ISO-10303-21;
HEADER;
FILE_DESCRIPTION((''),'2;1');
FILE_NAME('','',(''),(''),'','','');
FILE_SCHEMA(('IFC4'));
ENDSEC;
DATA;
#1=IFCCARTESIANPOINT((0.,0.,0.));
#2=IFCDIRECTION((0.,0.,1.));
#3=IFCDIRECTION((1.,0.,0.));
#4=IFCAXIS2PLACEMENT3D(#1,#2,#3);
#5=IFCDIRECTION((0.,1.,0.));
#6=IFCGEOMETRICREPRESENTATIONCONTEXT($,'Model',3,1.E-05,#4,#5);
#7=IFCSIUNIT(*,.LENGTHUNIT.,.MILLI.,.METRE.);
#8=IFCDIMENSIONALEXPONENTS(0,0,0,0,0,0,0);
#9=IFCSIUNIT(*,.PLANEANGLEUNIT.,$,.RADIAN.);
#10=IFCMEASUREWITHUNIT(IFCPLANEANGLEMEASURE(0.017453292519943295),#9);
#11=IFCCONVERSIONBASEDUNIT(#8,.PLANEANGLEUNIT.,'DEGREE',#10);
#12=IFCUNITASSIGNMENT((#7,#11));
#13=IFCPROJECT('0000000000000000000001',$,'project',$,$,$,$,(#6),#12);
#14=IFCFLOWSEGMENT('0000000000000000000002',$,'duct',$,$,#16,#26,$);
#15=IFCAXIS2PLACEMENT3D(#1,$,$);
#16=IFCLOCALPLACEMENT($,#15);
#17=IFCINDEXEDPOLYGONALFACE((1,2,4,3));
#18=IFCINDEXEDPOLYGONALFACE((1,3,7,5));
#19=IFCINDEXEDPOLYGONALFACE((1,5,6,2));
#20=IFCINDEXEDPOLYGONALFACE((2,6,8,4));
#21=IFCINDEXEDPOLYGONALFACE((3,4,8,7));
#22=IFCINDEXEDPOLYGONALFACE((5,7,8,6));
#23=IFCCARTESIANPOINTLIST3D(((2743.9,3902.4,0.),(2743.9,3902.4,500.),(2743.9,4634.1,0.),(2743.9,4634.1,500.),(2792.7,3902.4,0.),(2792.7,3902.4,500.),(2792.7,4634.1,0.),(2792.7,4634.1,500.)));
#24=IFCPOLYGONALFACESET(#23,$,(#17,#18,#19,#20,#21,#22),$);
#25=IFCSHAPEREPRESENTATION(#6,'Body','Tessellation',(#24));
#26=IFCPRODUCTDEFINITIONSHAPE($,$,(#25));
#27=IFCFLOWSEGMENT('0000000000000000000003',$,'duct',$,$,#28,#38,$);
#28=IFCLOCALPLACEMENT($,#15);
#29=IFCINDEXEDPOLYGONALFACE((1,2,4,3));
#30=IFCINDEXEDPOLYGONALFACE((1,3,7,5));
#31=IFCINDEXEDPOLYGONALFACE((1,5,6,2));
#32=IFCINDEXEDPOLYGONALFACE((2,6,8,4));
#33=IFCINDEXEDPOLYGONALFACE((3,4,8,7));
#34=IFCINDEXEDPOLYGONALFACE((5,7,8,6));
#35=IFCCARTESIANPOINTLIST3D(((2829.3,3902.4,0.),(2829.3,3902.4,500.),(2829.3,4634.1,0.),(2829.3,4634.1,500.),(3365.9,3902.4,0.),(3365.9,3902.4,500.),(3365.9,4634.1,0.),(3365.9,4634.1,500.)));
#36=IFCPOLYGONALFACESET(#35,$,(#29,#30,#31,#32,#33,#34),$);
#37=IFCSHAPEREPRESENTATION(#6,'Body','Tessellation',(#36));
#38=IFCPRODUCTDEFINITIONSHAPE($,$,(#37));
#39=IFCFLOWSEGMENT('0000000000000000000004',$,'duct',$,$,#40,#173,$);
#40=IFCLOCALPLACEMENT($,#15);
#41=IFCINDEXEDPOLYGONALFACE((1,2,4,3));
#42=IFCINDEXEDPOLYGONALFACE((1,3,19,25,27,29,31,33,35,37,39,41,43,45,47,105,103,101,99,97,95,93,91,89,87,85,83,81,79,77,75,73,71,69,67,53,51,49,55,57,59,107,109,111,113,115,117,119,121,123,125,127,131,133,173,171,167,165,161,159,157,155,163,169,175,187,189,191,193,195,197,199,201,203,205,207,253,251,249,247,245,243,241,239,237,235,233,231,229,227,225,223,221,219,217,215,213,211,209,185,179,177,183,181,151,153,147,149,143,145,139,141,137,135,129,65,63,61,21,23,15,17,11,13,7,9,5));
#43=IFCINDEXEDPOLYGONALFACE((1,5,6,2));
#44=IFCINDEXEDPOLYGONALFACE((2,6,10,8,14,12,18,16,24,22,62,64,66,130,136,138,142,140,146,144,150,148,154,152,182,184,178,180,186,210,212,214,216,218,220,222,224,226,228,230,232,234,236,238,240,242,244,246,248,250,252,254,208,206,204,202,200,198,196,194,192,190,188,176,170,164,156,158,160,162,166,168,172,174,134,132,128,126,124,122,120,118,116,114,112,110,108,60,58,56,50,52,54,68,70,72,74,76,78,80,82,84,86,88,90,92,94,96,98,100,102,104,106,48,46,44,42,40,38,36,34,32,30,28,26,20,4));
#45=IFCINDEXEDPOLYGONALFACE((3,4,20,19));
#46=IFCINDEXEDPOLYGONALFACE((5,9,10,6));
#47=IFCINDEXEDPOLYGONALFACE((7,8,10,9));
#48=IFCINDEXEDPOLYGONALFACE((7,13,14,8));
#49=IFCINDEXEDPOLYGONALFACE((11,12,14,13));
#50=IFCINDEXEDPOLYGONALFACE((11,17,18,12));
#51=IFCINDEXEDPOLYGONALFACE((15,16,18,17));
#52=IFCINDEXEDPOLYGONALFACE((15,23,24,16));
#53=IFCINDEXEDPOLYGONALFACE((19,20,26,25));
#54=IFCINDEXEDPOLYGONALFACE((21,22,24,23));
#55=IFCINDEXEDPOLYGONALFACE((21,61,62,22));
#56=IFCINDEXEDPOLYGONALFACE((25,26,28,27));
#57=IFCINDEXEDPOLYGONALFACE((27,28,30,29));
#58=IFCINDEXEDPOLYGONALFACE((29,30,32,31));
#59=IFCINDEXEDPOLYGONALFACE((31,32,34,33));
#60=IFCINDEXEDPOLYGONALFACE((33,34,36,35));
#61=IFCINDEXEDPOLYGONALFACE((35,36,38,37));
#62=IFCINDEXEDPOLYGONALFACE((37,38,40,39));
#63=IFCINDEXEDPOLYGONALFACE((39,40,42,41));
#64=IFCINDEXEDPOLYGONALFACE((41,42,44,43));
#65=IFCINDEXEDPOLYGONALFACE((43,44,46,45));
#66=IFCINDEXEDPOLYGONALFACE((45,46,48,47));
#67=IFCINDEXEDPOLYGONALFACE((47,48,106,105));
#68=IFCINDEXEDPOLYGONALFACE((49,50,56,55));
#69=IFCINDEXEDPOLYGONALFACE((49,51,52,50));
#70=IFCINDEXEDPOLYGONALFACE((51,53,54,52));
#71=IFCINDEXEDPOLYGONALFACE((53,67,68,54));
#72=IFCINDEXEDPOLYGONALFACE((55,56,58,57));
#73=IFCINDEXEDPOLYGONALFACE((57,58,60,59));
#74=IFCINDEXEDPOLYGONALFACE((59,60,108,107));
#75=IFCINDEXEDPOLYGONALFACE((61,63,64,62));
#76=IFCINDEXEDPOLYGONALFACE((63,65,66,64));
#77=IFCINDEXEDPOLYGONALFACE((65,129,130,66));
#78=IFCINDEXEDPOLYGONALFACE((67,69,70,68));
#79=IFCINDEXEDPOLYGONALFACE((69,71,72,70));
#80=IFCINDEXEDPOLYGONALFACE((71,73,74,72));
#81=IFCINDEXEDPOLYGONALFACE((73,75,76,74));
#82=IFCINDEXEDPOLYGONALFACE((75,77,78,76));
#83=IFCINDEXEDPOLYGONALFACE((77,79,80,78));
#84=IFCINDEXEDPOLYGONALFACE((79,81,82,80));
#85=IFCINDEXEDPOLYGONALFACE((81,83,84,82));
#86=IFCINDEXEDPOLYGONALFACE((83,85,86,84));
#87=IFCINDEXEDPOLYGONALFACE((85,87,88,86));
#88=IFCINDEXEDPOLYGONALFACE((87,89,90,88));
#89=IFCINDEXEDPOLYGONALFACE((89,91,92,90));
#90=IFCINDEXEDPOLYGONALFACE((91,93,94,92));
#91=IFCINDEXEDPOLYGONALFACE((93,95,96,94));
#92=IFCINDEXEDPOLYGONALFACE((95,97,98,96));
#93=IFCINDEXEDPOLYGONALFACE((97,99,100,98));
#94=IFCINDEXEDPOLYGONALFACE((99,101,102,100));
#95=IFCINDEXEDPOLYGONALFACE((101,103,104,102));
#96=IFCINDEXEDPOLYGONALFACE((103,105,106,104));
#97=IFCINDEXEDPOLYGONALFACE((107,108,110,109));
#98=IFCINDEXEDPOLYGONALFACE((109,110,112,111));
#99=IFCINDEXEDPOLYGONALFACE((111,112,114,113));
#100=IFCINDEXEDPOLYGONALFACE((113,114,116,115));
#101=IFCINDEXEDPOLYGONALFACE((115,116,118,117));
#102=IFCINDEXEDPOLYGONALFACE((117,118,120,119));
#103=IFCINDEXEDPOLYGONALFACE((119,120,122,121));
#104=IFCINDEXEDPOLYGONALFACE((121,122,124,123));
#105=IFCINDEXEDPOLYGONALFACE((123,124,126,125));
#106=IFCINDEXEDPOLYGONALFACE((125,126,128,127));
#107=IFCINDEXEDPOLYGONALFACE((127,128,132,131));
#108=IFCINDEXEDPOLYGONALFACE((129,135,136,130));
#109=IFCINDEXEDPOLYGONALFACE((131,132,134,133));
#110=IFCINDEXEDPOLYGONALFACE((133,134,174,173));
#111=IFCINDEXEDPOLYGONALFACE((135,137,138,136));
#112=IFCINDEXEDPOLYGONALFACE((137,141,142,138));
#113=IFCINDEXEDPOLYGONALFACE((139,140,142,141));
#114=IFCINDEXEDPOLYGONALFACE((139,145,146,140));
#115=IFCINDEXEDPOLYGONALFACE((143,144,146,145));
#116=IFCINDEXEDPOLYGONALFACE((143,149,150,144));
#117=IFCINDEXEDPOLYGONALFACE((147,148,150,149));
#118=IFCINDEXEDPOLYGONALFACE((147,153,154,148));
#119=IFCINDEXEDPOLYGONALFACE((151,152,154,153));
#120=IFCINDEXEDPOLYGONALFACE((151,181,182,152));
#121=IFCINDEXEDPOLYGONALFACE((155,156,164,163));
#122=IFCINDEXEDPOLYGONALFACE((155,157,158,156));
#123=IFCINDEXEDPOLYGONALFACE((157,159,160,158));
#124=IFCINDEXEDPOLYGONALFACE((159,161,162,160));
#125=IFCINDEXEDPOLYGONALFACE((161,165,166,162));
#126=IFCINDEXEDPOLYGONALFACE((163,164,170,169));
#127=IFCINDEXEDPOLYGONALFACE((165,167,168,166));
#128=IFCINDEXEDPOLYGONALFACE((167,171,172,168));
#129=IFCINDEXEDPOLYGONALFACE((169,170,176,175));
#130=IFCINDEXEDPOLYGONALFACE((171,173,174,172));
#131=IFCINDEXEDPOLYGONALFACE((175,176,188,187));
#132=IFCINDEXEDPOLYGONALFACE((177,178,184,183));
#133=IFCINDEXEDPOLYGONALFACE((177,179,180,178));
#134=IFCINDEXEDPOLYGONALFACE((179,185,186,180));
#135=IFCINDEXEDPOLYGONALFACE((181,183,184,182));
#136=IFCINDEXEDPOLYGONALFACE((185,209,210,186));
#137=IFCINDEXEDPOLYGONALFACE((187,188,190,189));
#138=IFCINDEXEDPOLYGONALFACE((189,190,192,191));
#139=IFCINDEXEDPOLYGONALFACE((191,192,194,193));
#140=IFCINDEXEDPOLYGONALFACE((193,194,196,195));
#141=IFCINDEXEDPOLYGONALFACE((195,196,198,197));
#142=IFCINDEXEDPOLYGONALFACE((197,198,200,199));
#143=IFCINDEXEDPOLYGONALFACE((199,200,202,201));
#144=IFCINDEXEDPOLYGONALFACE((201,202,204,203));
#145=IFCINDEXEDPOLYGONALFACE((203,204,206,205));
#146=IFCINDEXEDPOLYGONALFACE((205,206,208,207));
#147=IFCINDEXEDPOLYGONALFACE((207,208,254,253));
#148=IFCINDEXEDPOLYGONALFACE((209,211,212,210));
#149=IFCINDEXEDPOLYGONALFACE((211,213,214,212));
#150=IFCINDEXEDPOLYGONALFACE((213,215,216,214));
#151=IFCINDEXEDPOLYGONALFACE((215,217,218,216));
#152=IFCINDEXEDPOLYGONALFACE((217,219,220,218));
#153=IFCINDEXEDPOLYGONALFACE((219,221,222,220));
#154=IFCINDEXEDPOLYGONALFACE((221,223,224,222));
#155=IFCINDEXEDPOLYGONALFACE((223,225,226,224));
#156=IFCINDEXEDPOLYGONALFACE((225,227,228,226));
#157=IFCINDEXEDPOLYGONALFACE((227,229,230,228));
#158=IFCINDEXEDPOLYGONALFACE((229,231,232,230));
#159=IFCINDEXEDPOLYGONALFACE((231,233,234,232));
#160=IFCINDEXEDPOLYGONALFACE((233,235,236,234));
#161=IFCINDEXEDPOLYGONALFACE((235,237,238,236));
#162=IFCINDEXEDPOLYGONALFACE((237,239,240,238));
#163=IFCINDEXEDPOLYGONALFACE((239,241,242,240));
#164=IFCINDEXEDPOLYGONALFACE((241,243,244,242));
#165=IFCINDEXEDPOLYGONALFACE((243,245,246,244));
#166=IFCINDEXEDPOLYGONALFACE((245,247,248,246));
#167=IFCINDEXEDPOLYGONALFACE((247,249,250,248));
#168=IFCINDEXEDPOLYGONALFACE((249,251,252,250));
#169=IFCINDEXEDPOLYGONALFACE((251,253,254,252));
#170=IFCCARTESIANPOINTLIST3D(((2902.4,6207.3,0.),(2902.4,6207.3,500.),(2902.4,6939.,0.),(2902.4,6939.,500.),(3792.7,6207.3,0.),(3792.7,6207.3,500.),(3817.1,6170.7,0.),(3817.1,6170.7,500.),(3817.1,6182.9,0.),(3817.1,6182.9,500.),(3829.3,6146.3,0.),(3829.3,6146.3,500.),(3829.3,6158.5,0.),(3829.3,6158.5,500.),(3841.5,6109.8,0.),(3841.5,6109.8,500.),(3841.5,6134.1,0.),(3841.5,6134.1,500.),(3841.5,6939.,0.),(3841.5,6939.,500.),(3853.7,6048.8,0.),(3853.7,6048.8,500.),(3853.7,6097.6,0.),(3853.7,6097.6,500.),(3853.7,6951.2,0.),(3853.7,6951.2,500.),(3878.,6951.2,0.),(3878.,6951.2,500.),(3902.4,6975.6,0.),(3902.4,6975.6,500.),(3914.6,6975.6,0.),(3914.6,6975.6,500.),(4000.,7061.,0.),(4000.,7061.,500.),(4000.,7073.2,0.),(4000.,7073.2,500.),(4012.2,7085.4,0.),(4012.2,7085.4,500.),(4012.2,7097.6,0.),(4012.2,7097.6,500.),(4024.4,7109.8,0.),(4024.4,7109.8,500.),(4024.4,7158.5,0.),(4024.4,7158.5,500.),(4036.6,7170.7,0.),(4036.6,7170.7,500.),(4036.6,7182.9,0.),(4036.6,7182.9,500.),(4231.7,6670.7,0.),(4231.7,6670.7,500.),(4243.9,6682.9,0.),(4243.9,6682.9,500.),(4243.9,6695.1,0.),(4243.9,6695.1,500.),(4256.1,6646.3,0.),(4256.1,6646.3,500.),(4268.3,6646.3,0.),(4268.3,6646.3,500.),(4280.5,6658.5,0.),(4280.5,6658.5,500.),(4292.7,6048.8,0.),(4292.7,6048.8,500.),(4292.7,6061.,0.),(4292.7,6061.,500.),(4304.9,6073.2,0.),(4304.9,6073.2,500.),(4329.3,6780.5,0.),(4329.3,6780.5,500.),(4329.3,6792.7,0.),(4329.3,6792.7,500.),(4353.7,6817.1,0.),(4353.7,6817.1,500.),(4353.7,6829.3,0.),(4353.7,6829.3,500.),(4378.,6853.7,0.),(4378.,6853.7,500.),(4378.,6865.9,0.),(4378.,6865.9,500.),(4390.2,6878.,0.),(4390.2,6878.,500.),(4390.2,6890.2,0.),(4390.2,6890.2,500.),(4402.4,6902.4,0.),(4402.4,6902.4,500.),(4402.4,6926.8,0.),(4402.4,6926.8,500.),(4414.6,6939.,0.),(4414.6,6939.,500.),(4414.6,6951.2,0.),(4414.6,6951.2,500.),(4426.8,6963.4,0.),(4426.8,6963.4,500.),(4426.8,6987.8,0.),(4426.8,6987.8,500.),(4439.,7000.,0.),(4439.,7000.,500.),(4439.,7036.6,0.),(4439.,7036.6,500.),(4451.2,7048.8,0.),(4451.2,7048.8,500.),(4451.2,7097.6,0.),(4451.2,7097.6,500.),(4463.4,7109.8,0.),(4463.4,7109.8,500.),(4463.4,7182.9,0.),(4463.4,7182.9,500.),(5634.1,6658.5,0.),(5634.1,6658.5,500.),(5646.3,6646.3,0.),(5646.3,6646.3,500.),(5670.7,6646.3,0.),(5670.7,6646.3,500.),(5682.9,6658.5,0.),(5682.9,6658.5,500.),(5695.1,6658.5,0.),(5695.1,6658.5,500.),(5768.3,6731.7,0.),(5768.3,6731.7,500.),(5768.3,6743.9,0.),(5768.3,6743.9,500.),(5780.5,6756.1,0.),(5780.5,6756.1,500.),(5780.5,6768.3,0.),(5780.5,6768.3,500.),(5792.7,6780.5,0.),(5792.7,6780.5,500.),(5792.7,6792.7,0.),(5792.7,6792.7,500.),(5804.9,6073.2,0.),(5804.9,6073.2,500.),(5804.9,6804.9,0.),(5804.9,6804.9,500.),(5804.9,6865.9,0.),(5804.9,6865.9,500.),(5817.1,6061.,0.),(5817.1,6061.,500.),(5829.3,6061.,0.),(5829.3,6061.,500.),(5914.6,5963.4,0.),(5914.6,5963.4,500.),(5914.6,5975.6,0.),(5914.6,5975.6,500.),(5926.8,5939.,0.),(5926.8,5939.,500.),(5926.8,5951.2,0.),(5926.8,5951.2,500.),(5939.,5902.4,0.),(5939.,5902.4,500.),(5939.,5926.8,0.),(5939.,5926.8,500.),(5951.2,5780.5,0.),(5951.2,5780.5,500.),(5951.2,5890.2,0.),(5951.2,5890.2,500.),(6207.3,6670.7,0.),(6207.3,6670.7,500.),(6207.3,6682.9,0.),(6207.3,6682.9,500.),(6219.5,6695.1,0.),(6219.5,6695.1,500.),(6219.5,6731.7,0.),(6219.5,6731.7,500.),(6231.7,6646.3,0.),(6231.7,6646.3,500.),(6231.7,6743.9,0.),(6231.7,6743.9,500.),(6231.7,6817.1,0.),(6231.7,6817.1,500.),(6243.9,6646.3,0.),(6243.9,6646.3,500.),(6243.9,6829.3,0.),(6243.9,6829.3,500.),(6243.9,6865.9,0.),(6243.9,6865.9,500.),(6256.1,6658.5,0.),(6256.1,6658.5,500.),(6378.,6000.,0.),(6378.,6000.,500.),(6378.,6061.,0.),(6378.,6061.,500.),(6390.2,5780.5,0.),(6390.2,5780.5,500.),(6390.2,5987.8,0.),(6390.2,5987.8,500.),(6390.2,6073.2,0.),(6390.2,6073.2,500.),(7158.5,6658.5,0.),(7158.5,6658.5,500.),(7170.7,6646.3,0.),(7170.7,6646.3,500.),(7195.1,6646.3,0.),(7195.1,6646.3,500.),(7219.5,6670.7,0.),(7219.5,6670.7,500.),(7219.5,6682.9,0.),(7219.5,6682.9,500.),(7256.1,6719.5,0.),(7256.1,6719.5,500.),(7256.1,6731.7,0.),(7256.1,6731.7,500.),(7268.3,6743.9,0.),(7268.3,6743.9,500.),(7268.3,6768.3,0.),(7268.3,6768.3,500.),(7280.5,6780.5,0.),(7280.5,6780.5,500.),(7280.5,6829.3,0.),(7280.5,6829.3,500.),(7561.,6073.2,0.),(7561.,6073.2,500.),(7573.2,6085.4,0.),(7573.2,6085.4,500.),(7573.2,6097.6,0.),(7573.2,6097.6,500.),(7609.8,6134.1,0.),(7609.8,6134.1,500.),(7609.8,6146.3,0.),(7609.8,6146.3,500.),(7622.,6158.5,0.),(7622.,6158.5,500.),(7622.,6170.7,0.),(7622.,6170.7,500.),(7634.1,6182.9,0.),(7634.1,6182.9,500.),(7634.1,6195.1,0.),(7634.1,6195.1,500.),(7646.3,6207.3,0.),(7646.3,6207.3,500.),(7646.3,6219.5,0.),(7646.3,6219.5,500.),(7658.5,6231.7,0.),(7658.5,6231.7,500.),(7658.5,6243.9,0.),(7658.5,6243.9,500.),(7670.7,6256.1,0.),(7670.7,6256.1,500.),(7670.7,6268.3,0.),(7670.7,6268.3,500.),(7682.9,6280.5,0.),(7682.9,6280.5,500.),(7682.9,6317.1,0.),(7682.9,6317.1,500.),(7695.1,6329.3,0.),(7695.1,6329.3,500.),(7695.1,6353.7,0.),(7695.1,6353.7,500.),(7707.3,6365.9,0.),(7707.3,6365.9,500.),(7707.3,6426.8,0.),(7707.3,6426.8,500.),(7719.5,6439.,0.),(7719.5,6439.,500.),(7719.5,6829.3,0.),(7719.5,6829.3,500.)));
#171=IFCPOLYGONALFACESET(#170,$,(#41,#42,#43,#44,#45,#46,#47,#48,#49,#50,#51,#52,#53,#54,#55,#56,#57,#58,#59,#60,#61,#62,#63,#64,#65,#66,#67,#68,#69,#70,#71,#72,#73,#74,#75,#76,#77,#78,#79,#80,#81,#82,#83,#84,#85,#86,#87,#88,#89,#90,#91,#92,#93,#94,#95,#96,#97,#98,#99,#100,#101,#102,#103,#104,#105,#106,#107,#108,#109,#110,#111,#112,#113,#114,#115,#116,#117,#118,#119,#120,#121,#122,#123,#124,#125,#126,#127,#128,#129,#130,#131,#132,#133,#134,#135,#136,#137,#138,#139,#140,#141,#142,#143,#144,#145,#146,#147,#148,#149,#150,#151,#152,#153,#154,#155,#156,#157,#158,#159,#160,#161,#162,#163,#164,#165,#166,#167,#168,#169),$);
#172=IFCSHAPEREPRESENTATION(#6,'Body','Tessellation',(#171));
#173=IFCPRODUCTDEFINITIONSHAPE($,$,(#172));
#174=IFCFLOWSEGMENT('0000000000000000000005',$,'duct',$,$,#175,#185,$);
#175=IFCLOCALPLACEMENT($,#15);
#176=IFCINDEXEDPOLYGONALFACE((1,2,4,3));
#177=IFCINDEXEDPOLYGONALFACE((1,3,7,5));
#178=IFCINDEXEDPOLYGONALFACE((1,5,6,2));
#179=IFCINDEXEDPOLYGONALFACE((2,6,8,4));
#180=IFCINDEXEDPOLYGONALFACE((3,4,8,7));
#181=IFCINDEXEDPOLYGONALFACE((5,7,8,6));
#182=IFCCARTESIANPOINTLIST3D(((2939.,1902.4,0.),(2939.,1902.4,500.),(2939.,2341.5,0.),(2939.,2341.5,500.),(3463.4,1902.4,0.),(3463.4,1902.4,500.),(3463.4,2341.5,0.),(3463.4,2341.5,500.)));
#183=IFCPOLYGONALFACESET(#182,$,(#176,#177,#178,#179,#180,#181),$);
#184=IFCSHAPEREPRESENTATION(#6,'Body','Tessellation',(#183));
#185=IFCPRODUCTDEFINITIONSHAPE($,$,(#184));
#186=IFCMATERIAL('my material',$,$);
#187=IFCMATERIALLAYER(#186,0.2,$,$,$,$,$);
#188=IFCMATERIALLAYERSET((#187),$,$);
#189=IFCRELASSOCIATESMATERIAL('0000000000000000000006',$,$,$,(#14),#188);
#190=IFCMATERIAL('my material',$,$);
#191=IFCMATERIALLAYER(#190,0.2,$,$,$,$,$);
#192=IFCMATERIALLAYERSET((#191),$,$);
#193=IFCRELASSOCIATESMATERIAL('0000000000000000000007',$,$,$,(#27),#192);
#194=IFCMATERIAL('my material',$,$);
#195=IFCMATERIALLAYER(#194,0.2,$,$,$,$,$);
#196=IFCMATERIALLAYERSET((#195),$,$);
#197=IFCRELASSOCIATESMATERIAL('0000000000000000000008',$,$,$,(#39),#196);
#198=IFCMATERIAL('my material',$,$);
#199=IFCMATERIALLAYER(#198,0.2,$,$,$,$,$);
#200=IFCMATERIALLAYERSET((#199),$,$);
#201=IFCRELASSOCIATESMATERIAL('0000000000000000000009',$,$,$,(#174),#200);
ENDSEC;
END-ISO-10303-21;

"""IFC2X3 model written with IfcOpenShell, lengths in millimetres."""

from ifc_helpers import new_model, entity, si_unit, converted_unit, direction, origin_with_axes, place, context, project, polyline, outline, extrude, material, layer, layer_set, layer_usage, element, save


model = new_model("IFC2X3")

# Units and contexts
model_context = context("Model", 3, precision=1e-05, world=origin_with_axes(), true_north=direction((0.0, 1.0, 0.0)))
ifc_project = project(units=[si_unit("LENGTHUNIT", "METRE", prefix="MILLI"), converted_unit("PLANEANGLEUNIT", "DEGREE", entity("IfcPlaneAngleMeasure", 0.017453292519943295), si_unit("PLANEANGLEUNIT", "RADIAN"), dimensions=[0, 0, 0, 0, 0, 0, 0])], contexts=[model_context])

# Flow segments
ifc_material_1 = material(Name="my material")
ifc_layer_1 = layer(ifc_material_1, 0.2)
ifc_layer_set_1 = layer_set([ifc_layer_1])
ifc_layer_usage_1 = layer_usage(ifc_layer_set_1, "AXIS2", "POSITIVE", -0.1)
flow_segment_1_placement = place(None, origin_with_axes())
element("IfcFlowSegment", 1, at=flow_segment_1_placement, material=ifc_layer_usage_1, Name="duct", context=model_context, shape_type="SweptSolid", body=[
    extrude(outline(polyline([(2743.9, 3902.4), (2792.7, 3902.4), (2792.7, 4634.1), (2743.9, 4634.1), (2743.9, 3902.4)])), origin_with_axes(), (0.0, 0.0, 1.0), 500.0),
])
ifc_material_2 = material(Name="my material")
ifc_layer_2 = layer(ifc_material_2, 0.2)
ifc_layer_set_2 = layer_set([ifc_layer_2])
ifc_layer_usage_2 = layer_usage(ifc_layer_set_2, "AXIS2", "POSITIVE", -0.1)
flow_segment_2_placement = place(None, origin_with_axes())
element("IfcFlowSegment", 2, at=flow_segment_2_placement, material=ifc_layer_usage_2, Name="duct", context=model_context, shape_type="SweptSolid", body=[
    extrude(outline(polyline([(2829.3, 3902.4), (3365.9, 3902.4), (3365.9, 4634.1), (2829.3, 4634.1), (2829.3, 3902.4)])), origin_with_axes(), (0.0, 0.0, 1.0), 500.0),
])
ifc_material_3 = material(Name="my material")
ifc_layer_3 = layer(ifc_material_3, 0.2)
ifc_layer_set_3 = layer_set([ifc_layer_3])
ifc_layer_usage_3 = layer_usage(ifc_layer_set_3, "AXIS2", "POSITIVE", -0.1)
flow_segment_3_placement = place(None, origin_with_axes())
element("IfcFlowSegment", 3, at=flow_segment_3_placement, material=ifc_layer_usage_3, Name="duct", context=model_context, shape_type="SweptSolid", body=[
    extrude(outline(polyline([(2902.4, 6207.3), (3792.7, 6207.3), (3817.1, 6182.9), (3817.1, 6170.7), (3829.3, 6158.5), (3829.3, 6146.3), (3841.5, 6134.1), (3841.5, 6109.8), (3853.7, 6097.6), (3853.7, 6048.8), (4292.7, 6048.8), (4292.7, 6061.0), (4304.9, 6073.2), (5804.9, 6073.2), (5817.1, 6061.0), (5829.3, 6061.0), (5914.6, 5975.6), (5914.6, 5963.4), (5926.8, 5951.2), (5926.8, 5939.0), (5939.0, 5926.8), (5939.0, 5902.4), (5951.2, 5890.2), (5951.2, 5780.5), (6390.2, 5780.5), (6390.2, 5987.8), (6378.0, 6000.0), (6378.0, 6061.0), (6390.2, 6073.2), (7561.0, 6073.2), (7573.2, 6085.4), (7573.2, 6097.6), (7609.8, 6134.1), (7609.8, 6146.3), (7622.0, 6158.5), (7622.0, 6170.7), (7634.1, 6182.9), (7634.1, 6195.1), (7646.3, 6207.3), (7646.3, 6219.5), (7658.5, 6231.7), (7658.5, 6243.9), (7670.7, 6256.1), (7670.7, 6268.3), (7682.9, 6280.5), (7682.9, 6317.1), (7695.1, 6329.3), (7695.1, 6353.7), (7707.3, 6365.9), (7707.3, 6426.8), (7719.5, 6439.0), (7719.5, 6829.3), (7280.5, 6829.3), (7280.5, 6780.5), (7268.3, 6768.3), (7268.3, 6743.9), (7256.1, 6731.7), (7256.1, 6719.5), (7219.5, 6682.9), (7219.5, 6670.7), (7195.1, 6646.3), (7170.7, 6646.3), (7158.5, 6658.5), (6256.1, 6658.5), (6243.9, 6646.3), (6231.7, 6646.3), (6207.3, 6670.7), (6207.3, 6682.9), (6219.5, 6695.1), (6219.5, 6731.7), (6231.7, 6743.9), (6231.7, 6817.1), (6243.9, 6829.3), (6243.9, 6865.9), (5804.9, 6865.9), (5804.9, 6804.9), (5792.7, 6792.7), (5792.7, 6780.5), (5780.5, 6768.3), (5780.5, 6756.1), (5768.3, 6743.9), (5768.3, 6731.7), (5695.1, 6658.5), (5682.9, 6658.5), (5670.7, 6646.3), (5646.3, 6646.3), (5634.1, 6658.5), (4280.5, 6658.5), (4268.3, 6646.3), (4256.1, 6646.3), (4231.7, 6670.7), (4243.9, 6682.9), (4243.9, 6695.1), (4329.3, 6780.5), (4329.3, 6792.7), (4353.7, 6817.1), (4353.7, 6829.3), (4378.0, 6853.7), (4378.0, 6865.9), (4390.2, 6878.0), (4390.2, 6890.2), (4402.4, 6902.4), (4402.4, 6926.8), (4414.6, 6939.0), (4414.6, 6951.2), (4426.8, 6963.4), (4426.8, 6987.8), (4439.0, 7000.0), (4439.0, 7036.6), (4451.2, 7048.8), (4451.2, 7097.6), (4463.4, 7109.8), (4463.4, 7182.9), (4036.6, 7182.9), (4036.6, 7170.7), (4024.4, 7158.5), (4024.4, 7109.8), (4012.2, 7097.6), (4012.2, 7085.4), (4000.0, 7073.2), (4000.0, 7061.0), (3914.6, 6975.6), (3902.4, 6975.6), (3878.0, 6951.2), (3853.7, 6951.2), (3841.5, 6939.0), (2902.4, 6939.0), (2902.4, 6207.3)])), origin_with_axes(), (0.0, 0.0, 1.0), 500.0),
])
ifc_material_4 = material(Name="my material")
ifc_layer_4 = layer(ifc_material_4, 0.2)
ifc_layer_set_4 = layer_set([ifc_layer_4])
ifc_layer_usage_4 = layer_usage(ifc_layer_set_4, "AXIS2", "POSITIVE", -0.1)
flow_segment_4_placement = place(None, origin_with_axes())
element("IfcFlowSegment", 4, at=flow_segment_4_placement, material=ifc_layer_usage_4, Name="duct", context=model_context, shape_type="SweptSolid", body=[
    extrude(outline(polyline([(2939.0, 1902.4), (3463.4, 1902.4), (3463.4, 2341.5), (2939.0, 2341.5), (2939.0, 1902.4)])), origin_with_axes(), (0.0, 0.0, 1.0), 500.0),
])

save(model, "model.ifc")
